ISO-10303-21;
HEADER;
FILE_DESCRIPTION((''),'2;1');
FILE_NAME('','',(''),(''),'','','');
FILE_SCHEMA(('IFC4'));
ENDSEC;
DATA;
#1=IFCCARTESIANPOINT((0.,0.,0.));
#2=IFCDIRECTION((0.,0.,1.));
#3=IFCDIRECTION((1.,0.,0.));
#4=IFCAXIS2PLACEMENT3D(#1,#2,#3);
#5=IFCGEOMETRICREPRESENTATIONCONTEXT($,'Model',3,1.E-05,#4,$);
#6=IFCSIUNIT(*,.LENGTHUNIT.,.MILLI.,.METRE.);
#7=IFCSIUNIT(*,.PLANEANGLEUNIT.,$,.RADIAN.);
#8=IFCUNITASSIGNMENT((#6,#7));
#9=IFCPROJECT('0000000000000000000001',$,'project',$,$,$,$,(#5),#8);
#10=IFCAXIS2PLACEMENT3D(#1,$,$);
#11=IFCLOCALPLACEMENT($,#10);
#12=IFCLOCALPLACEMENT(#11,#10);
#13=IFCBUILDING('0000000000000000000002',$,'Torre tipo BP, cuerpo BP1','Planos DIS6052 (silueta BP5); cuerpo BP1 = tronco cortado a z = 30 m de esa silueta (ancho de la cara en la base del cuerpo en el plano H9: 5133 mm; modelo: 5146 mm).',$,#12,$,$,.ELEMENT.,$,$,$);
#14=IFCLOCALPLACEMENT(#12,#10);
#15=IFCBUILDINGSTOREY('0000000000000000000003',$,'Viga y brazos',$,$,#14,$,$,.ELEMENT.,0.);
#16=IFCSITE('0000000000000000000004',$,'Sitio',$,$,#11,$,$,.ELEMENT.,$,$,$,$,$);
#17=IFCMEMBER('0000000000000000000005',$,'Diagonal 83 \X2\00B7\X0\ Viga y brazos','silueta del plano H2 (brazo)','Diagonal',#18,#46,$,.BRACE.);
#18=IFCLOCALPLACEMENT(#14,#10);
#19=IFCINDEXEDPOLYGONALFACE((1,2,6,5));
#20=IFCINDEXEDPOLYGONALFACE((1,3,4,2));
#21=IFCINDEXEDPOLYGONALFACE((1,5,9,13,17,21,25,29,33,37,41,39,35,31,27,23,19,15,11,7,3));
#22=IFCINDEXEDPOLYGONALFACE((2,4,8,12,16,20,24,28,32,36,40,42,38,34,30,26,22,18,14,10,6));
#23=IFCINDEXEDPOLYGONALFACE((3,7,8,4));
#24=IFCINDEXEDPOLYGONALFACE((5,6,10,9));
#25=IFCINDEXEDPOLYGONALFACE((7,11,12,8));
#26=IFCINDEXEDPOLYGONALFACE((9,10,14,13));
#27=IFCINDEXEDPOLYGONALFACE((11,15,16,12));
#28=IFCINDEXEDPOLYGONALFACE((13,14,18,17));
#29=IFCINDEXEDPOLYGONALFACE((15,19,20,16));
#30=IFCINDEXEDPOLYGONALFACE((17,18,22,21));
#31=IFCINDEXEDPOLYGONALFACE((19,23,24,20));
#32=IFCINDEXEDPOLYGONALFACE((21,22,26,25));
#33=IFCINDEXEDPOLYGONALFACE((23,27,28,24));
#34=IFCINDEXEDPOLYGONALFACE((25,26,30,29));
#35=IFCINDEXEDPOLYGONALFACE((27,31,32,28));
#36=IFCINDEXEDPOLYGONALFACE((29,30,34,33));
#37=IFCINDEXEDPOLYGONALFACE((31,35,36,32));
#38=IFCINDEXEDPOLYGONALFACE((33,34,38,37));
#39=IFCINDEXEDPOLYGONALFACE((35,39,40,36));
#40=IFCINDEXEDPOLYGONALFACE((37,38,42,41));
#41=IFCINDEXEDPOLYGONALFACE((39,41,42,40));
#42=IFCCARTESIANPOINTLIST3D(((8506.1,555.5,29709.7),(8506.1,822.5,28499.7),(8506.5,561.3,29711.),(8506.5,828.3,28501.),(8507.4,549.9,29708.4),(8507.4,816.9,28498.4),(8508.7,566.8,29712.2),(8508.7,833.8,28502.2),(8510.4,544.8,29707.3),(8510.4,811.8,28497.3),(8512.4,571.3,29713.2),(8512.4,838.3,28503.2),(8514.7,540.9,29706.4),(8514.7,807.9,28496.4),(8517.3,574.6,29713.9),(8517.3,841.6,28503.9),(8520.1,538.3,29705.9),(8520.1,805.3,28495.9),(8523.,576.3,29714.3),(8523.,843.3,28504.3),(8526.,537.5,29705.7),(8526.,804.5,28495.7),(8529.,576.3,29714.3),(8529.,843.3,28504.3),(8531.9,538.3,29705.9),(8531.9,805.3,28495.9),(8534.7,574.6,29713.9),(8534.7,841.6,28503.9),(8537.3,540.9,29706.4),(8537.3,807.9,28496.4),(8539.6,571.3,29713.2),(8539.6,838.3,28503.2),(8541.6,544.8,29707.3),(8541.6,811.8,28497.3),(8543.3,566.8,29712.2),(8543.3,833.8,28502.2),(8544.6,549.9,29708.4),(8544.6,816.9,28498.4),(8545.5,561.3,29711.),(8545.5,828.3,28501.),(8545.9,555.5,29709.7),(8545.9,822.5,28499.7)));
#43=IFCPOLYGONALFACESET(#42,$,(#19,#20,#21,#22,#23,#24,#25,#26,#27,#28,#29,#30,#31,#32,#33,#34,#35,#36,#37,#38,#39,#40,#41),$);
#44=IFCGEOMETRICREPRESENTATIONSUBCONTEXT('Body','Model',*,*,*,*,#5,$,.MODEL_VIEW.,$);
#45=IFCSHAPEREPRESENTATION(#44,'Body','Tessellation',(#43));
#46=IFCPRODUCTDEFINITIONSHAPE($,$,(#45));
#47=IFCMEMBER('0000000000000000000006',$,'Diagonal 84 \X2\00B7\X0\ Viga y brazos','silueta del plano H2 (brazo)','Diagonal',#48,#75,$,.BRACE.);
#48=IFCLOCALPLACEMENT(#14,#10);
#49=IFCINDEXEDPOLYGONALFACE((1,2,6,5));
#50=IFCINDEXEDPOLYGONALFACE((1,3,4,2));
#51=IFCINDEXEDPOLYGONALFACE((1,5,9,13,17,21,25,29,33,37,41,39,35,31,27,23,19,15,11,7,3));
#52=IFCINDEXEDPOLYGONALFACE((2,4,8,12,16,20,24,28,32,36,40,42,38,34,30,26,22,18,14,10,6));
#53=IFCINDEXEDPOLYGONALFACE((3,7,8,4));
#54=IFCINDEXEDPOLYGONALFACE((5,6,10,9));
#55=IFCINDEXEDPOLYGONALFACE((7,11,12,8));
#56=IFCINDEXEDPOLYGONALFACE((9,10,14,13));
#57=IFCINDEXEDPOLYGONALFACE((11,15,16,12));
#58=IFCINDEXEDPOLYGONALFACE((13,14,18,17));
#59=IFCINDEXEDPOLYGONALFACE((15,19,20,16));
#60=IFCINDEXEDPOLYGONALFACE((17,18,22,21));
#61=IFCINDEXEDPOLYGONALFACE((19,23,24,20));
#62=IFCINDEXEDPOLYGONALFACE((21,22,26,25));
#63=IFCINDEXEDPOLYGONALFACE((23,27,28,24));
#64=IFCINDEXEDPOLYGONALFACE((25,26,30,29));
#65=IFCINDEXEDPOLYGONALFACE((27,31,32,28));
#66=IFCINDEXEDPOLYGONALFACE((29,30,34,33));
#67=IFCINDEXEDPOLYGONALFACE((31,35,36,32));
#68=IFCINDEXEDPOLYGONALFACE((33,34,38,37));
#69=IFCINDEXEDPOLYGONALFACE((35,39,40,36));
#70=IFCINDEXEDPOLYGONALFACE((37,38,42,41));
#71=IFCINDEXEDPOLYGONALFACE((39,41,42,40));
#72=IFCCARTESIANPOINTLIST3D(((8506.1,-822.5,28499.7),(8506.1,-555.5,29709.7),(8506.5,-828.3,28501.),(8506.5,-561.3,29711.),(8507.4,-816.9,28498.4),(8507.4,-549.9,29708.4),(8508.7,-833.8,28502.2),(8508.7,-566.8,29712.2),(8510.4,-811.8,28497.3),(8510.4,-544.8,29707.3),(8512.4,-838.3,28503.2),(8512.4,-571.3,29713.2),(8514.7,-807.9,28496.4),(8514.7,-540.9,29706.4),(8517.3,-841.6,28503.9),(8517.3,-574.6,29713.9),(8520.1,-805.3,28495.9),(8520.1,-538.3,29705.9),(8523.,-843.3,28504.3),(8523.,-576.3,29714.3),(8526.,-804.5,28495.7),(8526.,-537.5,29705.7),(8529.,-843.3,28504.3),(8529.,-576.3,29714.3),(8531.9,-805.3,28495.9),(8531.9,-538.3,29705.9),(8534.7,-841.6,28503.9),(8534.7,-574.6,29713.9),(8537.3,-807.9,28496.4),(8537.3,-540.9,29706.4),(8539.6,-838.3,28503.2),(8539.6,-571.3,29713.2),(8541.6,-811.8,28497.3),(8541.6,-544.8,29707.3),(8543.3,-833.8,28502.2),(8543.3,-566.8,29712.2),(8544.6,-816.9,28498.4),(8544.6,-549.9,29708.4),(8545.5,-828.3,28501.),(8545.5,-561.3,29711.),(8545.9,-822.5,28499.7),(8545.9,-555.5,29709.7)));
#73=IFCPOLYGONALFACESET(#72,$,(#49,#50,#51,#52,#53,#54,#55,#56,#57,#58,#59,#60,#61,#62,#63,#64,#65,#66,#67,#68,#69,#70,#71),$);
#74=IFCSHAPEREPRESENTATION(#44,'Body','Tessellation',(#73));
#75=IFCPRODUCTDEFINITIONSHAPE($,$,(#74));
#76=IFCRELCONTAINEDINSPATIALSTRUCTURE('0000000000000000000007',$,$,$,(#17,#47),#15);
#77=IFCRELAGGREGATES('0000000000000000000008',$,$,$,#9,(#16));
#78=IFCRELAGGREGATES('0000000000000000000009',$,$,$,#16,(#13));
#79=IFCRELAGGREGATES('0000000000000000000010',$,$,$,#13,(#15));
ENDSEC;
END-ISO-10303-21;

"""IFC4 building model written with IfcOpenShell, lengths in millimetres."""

from ifc_helpers import new_model, si_unit, frame, origin, origin_with_axes, place, context, subcontext, project, spatial, circle, extrude, element, save


model = new_model("IFC4")

# Units and contexts
model_context = context("Model", 3, precision=1e-05, world=origin_with_axes())
body_context = subcontext(model_context, "Body", "Model", "MODEL_VIEW")
ifc_project = project(units=[si_unit("LENGTHUNIT", "METRE", prefix="MILLI"), si_unit("PLANEANGLEUNIT", "RADIAN")], contexts=[model_context])

# Site, building, storey
site_placement = place(None, origin())
site = spatial("IfcSite", under=ifc_project, at=site_placement, Name="Sitio", CompositionType="ELEMENT")
building_placement = place(site_placement, origin())
building = spatial("IfcBuilding", under=site, at=building_placement, Name="Torre tipo BP, cuerpo BP1", Description="Planos DIS6052 (silueta BP5); cuerpo BP1 = tronco cortado a z = 30 m de esa silueta (ancho de la cara en la base del cuerpo en el plano H9: 5133 mm; modelo: 5146 mm).", CompositionType="ELEMENT")
storey_placement = place(building_placement, origin())
storey = spatial("IfcBuildingStorey", under=building, at=storey_placement, Name="Viga y brazos", CompositionType="ELEMENT", Elevation=0.0)

# Members
for number, where, z_axis, x_axis, name in (
    (1, (8526.0, 557.0, 29710.0), (0.0, 0.215478, -0.976509), (0.0, -0.976509, -0.215478), "Diagonal 83 · Viga y brazos"),
    (2, (8526.0, -557.0, 29710.0), (0.0, -0.215478, -0.976509), (0.0, 0.976509, -0.215478), "Diagonal 84 · Viga y brazos"),
):
    element("IfcMember", number, at=place(storey_placement, frame(where, z_axis=z_axis, x_axis=x_axis)), inside=storey, Name=name, Description="silueta del plano H2 (brazo)", ObjectType="Diagonal", PredefinedType="BRACE", context=body_context, shape_type="SweptSolid", body=[
        extrude(circle(Radius=20.0), None, (0.0, 0.0, 1.0), 1239.1),
    ])

save(model, "model.ifc")
